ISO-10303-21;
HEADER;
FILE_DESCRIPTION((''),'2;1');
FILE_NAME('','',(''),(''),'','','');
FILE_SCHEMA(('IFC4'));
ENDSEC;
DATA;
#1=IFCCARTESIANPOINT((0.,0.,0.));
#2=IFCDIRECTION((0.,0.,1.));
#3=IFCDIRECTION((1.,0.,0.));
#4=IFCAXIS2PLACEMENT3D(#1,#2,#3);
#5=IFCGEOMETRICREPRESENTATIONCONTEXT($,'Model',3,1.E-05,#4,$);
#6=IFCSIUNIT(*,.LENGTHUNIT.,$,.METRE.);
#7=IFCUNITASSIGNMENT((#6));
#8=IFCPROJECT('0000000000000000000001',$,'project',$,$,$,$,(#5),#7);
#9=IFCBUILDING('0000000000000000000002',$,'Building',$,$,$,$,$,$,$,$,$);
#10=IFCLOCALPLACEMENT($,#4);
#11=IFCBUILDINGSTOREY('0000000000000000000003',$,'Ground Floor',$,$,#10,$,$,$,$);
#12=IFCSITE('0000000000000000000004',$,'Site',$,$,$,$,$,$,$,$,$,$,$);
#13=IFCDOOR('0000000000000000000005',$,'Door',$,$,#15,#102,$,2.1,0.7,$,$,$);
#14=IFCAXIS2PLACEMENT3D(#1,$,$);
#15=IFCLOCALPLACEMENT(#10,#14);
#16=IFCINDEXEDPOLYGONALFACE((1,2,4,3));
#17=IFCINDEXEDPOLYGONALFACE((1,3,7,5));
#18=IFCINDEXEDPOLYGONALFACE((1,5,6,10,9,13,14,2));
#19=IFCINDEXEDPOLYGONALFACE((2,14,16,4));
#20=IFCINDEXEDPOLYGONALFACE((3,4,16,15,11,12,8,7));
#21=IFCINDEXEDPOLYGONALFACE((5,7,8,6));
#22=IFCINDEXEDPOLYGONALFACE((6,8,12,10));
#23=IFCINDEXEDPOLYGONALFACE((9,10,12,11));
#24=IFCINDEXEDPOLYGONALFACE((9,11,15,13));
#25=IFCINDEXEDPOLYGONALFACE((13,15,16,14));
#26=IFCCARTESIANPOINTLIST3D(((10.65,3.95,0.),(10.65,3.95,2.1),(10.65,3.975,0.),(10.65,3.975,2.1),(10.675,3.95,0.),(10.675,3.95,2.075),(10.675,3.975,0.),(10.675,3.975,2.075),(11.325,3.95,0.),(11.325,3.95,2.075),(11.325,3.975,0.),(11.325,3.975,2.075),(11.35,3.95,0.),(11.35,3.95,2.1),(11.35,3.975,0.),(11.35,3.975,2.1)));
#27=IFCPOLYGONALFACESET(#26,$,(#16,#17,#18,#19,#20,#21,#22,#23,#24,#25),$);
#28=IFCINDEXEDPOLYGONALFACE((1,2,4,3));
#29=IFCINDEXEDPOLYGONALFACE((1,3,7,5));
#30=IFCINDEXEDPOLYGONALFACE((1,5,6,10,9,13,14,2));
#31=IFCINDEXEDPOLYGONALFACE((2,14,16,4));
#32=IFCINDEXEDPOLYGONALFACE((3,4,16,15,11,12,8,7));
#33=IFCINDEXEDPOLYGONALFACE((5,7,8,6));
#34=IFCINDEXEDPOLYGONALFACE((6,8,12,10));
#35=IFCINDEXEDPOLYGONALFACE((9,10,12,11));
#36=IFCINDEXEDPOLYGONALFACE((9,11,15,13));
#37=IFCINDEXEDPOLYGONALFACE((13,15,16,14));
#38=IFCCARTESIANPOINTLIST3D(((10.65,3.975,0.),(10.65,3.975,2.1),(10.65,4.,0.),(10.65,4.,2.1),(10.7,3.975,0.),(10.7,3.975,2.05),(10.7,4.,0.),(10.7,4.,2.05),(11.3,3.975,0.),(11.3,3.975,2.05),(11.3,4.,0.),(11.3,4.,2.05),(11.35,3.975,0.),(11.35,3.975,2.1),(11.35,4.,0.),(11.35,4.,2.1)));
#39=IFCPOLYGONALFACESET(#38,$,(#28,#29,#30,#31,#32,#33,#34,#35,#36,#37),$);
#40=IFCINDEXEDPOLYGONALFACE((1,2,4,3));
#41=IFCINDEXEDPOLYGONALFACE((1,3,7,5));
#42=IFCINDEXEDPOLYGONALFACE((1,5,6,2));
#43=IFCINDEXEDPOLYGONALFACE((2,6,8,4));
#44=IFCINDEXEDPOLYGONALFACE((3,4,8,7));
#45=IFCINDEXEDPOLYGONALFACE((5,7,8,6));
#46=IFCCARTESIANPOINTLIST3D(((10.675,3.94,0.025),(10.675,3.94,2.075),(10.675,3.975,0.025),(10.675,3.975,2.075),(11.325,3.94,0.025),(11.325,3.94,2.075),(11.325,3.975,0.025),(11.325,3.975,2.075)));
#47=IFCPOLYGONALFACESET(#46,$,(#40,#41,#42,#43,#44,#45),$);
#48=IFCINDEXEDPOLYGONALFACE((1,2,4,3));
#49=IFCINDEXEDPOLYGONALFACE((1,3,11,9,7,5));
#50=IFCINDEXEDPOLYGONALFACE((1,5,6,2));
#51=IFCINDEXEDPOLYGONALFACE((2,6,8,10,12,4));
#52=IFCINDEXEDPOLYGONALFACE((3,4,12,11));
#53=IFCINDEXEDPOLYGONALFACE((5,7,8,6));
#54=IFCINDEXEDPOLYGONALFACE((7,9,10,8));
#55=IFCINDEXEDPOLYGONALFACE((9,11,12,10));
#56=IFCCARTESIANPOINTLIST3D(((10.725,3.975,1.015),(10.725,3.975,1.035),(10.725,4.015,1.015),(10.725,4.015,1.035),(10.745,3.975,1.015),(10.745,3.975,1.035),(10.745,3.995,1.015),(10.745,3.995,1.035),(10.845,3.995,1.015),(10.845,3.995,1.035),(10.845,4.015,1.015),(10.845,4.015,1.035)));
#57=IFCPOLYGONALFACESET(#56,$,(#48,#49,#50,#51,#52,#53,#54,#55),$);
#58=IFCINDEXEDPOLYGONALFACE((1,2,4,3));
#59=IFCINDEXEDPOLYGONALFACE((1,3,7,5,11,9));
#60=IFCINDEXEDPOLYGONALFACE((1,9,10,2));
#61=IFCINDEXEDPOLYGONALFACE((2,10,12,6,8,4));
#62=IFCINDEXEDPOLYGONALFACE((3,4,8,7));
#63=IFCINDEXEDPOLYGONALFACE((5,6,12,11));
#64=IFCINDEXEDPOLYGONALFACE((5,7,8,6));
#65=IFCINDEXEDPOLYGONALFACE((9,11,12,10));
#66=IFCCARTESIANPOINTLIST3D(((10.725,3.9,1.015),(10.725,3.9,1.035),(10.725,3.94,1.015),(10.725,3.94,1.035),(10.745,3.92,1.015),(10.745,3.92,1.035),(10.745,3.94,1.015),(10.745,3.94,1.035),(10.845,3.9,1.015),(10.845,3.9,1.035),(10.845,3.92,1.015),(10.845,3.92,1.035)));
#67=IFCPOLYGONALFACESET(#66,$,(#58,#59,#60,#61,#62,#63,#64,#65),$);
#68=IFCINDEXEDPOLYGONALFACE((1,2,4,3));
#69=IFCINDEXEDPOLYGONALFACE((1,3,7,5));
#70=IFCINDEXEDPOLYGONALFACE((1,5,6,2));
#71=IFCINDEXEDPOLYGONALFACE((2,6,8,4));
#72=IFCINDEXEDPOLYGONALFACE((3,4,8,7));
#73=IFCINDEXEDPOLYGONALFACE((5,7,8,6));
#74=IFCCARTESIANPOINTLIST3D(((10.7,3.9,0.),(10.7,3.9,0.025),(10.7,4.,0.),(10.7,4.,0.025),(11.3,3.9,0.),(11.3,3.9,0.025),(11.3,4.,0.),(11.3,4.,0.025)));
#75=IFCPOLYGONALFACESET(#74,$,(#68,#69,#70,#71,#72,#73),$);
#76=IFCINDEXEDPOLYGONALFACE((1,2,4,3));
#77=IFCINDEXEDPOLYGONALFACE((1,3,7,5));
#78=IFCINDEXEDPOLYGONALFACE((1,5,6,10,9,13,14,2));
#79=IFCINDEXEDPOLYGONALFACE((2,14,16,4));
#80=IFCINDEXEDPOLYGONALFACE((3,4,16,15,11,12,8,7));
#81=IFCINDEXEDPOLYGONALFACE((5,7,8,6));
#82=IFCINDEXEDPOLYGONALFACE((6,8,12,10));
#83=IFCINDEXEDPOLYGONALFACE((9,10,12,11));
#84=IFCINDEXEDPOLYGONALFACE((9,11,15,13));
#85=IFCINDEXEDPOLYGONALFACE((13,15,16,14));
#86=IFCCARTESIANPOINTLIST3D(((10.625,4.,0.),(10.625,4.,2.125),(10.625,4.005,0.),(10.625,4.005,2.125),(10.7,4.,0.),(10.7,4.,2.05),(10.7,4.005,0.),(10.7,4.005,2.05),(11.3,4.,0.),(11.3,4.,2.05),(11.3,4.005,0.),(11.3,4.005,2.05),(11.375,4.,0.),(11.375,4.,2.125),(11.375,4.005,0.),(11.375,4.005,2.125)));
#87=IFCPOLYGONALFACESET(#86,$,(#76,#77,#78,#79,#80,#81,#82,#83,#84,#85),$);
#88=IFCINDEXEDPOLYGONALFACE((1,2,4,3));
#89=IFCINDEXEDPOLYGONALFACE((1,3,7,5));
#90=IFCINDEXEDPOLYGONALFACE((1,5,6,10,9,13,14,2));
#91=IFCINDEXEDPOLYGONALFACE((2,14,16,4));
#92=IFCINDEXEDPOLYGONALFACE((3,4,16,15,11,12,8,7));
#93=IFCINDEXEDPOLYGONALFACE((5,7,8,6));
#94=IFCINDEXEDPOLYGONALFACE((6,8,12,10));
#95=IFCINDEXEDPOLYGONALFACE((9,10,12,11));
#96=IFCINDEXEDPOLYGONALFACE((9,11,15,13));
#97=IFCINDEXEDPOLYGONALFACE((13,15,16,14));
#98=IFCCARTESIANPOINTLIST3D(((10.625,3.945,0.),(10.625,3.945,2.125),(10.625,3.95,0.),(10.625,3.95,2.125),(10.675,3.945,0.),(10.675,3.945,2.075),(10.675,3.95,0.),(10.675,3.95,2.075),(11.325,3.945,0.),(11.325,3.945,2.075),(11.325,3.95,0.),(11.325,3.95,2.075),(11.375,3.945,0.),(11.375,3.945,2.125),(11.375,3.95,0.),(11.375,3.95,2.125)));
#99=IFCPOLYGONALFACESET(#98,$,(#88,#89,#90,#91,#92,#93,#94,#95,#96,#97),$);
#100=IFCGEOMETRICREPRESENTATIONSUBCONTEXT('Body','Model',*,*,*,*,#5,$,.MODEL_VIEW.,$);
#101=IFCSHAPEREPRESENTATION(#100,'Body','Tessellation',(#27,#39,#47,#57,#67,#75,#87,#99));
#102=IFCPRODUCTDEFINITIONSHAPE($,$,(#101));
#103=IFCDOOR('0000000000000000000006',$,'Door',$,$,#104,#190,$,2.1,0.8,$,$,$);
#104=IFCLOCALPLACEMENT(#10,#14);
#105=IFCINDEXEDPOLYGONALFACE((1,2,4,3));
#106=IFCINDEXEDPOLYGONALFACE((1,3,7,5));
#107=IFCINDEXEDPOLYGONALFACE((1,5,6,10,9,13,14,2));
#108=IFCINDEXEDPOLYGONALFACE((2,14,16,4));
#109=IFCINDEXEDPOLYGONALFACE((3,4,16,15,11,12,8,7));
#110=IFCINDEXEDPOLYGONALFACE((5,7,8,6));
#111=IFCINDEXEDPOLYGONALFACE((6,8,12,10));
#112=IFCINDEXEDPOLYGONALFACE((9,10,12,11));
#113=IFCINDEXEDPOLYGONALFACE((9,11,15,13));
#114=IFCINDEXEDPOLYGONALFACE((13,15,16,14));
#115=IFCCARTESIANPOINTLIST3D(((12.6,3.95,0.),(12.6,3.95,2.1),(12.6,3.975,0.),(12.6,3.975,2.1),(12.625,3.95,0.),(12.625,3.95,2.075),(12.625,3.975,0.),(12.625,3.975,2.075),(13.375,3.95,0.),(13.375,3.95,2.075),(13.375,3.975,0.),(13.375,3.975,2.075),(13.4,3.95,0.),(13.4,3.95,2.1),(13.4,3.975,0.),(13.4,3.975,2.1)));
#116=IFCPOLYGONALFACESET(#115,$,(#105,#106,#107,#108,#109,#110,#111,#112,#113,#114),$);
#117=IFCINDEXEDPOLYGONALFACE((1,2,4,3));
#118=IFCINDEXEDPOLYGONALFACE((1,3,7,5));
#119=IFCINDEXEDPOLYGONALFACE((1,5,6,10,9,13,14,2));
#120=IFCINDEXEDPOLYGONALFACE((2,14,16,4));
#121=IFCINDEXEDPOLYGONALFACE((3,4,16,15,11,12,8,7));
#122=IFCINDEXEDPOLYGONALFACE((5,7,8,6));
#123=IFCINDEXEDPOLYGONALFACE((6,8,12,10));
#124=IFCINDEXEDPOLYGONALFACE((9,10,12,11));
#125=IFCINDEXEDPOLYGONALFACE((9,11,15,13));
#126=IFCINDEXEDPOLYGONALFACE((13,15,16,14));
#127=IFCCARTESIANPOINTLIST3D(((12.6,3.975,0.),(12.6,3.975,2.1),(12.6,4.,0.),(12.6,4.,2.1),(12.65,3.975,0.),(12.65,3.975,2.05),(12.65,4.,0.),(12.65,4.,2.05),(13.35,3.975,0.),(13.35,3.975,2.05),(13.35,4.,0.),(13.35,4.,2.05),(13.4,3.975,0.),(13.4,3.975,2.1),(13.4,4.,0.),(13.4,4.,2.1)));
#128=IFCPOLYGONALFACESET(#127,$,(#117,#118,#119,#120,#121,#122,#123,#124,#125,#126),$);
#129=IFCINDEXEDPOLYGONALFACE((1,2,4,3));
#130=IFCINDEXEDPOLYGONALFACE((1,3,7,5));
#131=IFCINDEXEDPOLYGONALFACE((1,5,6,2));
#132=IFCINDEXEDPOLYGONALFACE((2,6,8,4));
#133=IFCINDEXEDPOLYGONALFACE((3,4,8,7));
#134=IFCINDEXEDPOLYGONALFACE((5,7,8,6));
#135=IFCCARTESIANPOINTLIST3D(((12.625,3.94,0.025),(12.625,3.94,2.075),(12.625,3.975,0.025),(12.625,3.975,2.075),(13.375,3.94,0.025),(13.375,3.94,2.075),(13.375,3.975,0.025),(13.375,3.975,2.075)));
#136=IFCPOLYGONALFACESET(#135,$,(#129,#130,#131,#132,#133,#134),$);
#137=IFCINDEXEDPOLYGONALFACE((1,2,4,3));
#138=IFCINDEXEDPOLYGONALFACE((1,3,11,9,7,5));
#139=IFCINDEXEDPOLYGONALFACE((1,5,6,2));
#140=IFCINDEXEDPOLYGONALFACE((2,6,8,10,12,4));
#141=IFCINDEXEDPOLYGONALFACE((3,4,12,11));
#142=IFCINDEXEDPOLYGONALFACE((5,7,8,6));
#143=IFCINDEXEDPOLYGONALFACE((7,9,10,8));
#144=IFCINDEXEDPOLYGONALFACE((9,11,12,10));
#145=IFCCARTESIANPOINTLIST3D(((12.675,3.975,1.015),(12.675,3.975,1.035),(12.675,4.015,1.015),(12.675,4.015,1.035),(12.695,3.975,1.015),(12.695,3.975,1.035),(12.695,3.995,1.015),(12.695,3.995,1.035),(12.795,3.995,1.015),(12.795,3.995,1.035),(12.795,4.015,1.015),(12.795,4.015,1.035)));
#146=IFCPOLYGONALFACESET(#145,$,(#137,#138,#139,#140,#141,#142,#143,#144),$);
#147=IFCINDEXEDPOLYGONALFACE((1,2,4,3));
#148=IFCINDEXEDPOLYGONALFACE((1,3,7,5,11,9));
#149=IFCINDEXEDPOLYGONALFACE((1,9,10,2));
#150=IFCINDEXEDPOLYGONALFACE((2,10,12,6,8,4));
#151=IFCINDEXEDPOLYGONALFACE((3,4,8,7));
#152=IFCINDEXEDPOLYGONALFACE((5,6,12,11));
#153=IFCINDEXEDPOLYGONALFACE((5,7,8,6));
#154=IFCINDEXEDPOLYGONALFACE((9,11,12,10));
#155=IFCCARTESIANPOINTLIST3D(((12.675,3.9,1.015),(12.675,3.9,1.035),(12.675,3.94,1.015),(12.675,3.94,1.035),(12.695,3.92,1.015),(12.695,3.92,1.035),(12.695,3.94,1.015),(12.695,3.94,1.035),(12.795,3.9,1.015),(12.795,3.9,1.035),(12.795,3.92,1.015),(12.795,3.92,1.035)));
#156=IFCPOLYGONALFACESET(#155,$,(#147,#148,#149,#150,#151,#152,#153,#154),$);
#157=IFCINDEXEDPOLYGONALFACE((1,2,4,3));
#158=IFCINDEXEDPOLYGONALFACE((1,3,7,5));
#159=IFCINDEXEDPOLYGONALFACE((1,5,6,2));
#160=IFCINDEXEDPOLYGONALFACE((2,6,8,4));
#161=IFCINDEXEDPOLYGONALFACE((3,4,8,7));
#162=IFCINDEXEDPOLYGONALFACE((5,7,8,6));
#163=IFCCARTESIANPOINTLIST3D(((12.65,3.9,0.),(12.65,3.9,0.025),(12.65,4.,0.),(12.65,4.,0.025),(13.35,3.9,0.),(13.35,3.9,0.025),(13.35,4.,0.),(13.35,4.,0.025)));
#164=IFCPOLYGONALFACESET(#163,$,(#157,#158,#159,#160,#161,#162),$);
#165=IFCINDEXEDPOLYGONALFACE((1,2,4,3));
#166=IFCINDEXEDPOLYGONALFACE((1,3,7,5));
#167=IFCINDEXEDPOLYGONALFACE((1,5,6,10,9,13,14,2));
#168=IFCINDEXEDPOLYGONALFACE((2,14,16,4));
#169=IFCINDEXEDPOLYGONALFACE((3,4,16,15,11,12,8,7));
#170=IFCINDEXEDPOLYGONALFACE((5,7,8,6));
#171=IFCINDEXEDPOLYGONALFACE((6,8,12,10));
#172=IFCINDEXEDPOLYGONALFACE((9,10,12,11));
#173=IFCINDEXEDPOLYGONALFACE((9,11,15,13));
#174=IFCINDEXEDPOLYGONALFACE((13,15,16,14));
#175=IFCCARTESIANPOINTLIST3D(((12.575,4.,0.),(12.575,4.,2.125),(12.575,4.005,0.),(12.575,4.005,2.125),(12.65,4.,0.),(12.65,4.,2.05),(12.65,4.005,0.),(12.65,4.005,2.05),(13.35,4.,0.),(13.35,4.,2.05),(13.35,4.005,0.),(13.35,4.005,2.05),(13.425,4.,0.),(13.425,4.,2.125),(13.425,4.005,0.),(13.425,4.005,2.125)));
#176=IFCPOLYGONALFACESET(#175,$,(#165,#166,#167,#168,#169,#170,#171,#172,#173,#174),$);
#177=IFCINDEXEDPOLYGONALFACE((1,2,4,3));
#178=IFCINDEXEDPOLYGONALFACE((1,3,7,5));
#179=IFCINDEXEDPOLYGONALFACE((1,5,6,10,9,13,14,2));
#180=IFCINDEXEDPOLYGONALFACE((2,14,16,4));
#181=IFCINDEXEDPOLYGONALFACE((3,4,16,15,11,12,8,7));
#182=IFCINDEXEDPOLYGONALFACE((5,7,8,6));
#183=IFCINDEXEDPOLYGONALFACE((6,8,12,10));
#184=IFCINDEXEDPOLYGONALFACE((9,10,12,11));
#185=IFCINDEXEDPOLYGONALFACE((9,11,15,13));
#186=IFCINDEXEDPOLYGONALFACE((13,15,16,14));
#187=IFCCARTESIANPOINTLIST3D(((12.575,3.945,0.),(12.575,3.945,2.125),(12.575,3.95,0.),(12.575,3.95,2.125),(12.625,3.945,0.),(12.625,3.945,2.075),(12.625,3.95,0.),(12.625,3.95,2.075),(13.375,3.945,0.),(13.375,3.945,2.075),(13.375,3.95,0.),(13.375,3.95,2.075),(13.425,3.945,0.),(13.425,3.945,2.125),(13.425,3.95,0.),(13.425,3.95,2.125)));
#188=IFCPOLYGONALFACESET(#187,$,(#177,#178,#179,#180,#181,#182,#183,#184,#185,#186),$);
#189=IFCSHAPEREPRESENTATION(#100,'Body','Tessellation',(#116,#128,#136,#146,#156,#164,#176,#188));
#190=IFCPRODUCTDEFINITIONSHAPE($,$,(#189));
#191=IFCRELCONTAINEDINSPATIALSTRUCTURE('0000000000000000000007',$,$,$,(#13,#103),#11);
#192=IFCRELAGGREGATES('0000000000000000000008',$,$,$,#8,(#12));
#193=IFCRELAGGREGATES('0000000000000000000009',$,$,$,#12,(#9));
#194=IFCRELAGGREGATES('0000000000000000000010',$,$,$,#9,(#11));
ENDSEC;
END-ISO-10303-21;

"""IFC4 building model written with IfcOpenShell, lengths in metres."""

from ifc_helpers import new_model, si_unit, frame, origin_with_axes, place, context, subcontext, project, spatial, line, indexed_curve, outline, extrude, element, save


model = new_model("IFC4")

# Units and contexts
model_context = context("Model", 3, precision=1e-05, world=origin_with_axes())
body_context = subcontext(model_context, "Body", "Model", "MODEL_VIEW")
ifc_project = project(units=[si_unit("LENGTHUNIT", "METRE")], contexts=[model_context])

# Site, building, storey
site = spatial("IfcSite", under=ifc_project, Name="Site")
building = spatial("IfcBuilding", under=site, Name="Building")
storey_placement = place(None, origin_with_axes())
storey = spatial("IfcBuildingStorey", under=building, at=storey_placement, Name="Ground Floor")

# Doors
door_1_placement = place(storey_placement, frame((11.35, 4.0, 0.0), z_axis=(0.0, 0.0, 1.0), x_axis=(-1.0, 0.0, 0.0)))
element("IfcDoor", 1, at=door_1_placement, inside=storey, Name="Door", OverallHeight=2.1, OverallWidth=0.7, context=body_context, shape_type="SweptSolid", body=[
    extrude(outline(indexed_curve([(0.0, 0.0), (0.0, 2.1), (0.7, 2.1), (0.7, 0.0), (0.675, 0.0), (0.675, 2.075), (0.025, 2.075), (0.025, 0.0)], segments=[line(1, 2, 3, 4, 5, 6, 7, 8, 1)])), frame((0.0, 0.025, 0.0), z_axis=(0.0, -1.0, 0.0), x_axis=(1.0, 0.0, 0.0)), (0.0, 0.0, -1.0), 0.025),
    extrude(outline(indexed_curve([(0.0, 0.0), (0.0, 2.1), (0.7, 2.1), (0.7, 0.0), (0.65, 0.0), (0.65, 2.05), (0.05, 2.05), (0.05, 0.0)], segments=[line(1, 2, 3, 4, 5, 6, 7, 8, 1)])), frame((0.0, 0.0, 0.0), z_axis=(0.0, -1.0, 0.0), x_axis=(1.0, 0.0, 0.0)), (0.0, 0.0, -1.0), 0.025),
    extrude(outline(indexed_curve([(0.0, 0.0), (0.65, 0.0), (0.65, 0.035), (0.0, 0.035)], segments=[line(1, 2, 3, 4, 1)])), frame((0.025, 0.025, 0.025), z_axis=(0.0, 0.0, 1.0), x_axis=(1.0, 0.0, 0.0)), (0.0, 0.0, 1.0), 2.05),
    extrude(outline(indexed_curve([(0.0, 0.0), (0.0, -0.04), (-0.12, -0.04), (-0.12, -0.02), (-0.02, -0.02), (-0.02, 0.0)], segments=[line(1, 2, 3, 4, 5, 6, 1)])), frame((0.625, 0.025, 1.015), z_axis=(0.0, 0.0, 1.0), x_axis=(1.0, 0.0, 0.0)), (0.0, 0.0, 1.0), 0.02),
    extrude(outline(indexed_curve([(0.0, 0.0), (0.0, 0.04), (-0.12, 0.04), (-0.12, 0.02), (-0.02, 0.02), (-0.02, 0.0)], segments=[line(1, 2, 3, 4, 5, 6, 1)])), frame((0.625, 0.06, 1.015), z_axis=(0.0, 0.0, 1.0), x_axis=(1.0, 0.0, 0.0)), (0.0, 0.0, 1.0), 0.02),
    extrude(outline(indexed_curve([(0.0, 0.0), (0.6, 0.0), (0.6, 0.1), (0.0, 0.1)], segments=[line(1, 2, 3, 4, 1)])), frame((0.05, 0.0, 0.0), z_axis=(0.0, 0.0, 1.0), x_axis=(1.0, 0.0, 0.0)), (0.0, 0.0, 1.0), 0.025),
    extrude(outline(indexed_curve([(0.0, 0.0), (0.0, 2.125), (0.75, 2.125), (0.75, 0.0), (0.675, 0.0), (0.675, 2.05), (0.075, 2.05), (0.075, 0.0)], segments=[line(1, 2, 3, 4, 5, 6, 7, 8, 1)])), frame((-0.025, -0.005, 0.0), z_axis=(0.0, -1.0, 0.0), x_axis=(1.0, 0.0, 0.0)), (0.0, 0.0, -1.0), 0.005),
    extrude(outline(indexed_curve([(0.0, 0.0), (0.0, 2.125), (0.75, 2.125), (0.75, 0.0), (0.7, 0.0), (0.7, 2.075), (0.05, 2.075), (0.05, 0.0)], segments=[line(1, 2, 3, 4, 5, 6, 7, 8, 1)])), frame((-0.025, 0.05, 0.0), z_axis=(0.0, -1.0, 0.0), x_axis=(1.0, 0.0, 0.0)), (0.0, 0.0, -1.0), 0.005),
])
door_2_placement = place(storey_placement, frame((13.4, 4.0, 0.0), z_axis=(0.0, 0.0, 1.0), x_axis=(-1.0, 0.0, 0.0)))
element("IfcDoor", 2, at=door_2_placement, inside=storey, Name="Door", OverallHeight=2.1, OverallWidth=0.8, context=body_context, shape_type="SweptSolid", body=[
    extrude(outline(indexed_curve([(0.0, 0.0), (0.0, 2.1), (0.8, 2.1), (0.8, 0.0), (0.775, 0.0), (0.775, 2.075), (0.025, 2.075), (0.025, 0.0)], segments=[line(1, 2, 3, 4, 5, 6, 7, 8, 1)])), frame((0.0, 0.025, 0.0), z_axis=(0.0, -1.0, 0.0), x_axis=(1.0, 0.0, 0.0)), (0.0, 0.0, -1.0), 0.025),
    extrude(outline(indexed_curve([(0.0, 0.0), (0.0, 2.1), (0.8, 2.1), (0.8, 0.0), (0.75, 0.0), (0.75, 2.05), (0.05, 2.05), (0.05, 0.0)], segments=[line(1, 2, 3, 4, 5, 6, 7, 8, 1)])), frame((0.0, 0.0, 0.0), z_axis=(0.0, -1.0, 0.0), x_axis=(1.0, 0.0, 0.0)), (0.0, 0.0, -1.0), 0.025),
    extrude(outline(indexed_curve([(0.0, 0.0), (0.75, 0.0), (0.75, 0.035), (0.0, 0.035)], segments=[line(1, 2, 3, 4, 1)])), frame((0.025, 0.025, 0.025), z_axis=(0.0, 0.0, 1.0), x_axis=(1.0, 0.0, 0.0)), (0.0, 0.0, 1.0), 2.05),
    extrude(outline(indexed_curve([(0.0, 0.0), (0.0, -0.04), (-0.12, -0.04), (-0.12, -0.02), (-0.02, -0.02), (-0.02, 0.0)], segments=[line(1, 2, 3, 4, 5, 6, 1)])), frame((0.725, 0.025, 1.015), z_axis=(0.0, 0.0, 1.0), x_axis=(1.0, 0.0, 0.0)), (0.0, 0.0, 1.0), 0.02),
    extrude(outline(indexed_curve([(0.0, 0.0), (0.0, 0.04), (-0.12, 0.04), (-0.12, 0.02), (-0.02, 0.02), (-0.02, 0.0)], segments=[line(1, 2, 3, 4, 5, 6, 1)])), frame((0.725, 0.06, 1.015), z_axis=(0.0, 0.0, 1.0), x_axis=(1.0, 0.0, 0.0)), (0.0, 0.0, 1.0), 0.02),
    extrude(outline(indexed_curve([(0.0, 0.0), (0.7, 0.0), (0.7, 0.1), (0.0, 0.1)], segments=[line(1, 2, 3, 4, 1)])), frame((0.05, 0.0, 0.0), z_axis=(0.0, 0.0, 1.0), x_axis=(1.0, 0.0, 0.0)), (0.0, 0.0, 1.0), 0.025),
    extrude(outline(indexed_curve([(0.0, 0.0), (0.0, 2.125), (0.85, 2.125), (0.85, 0.0), (0.775, 0.0), (0.775, 2.05), (0.075, 2.05), (0.075, 0.0)], segments=[line(1, 2, 3, 4, 5, 6, 7, 8, 1)])), frame((-0.025, -0.005, 0.0), z_axis=(0.0, -1.0, 0.0), x_axis=(1.0, 0.0, 0.0)), (0.0, 0.0, -1.0), 0.005),
    extrude(outline(indexed_curve([(0.0, 0.0), (0.0, 2.125), (0.85, 2.125), (0.85, 0.0), (0.8, 0.0), (0.8, 2.075), (0.05, 2.075), (0.05, 0.0)], segments=[line(1, 2, 3, 4, 5, 6, 7, 8, 1)])), frame((-0.025, 0.05, 0.0), z_axis=(0.0, -1.0, 0.0), x_axis=(1.0, 0.0, 0.0)), (0.0, 0.0, -1.0), 0.005),
])

save(model, "model.ifc")
